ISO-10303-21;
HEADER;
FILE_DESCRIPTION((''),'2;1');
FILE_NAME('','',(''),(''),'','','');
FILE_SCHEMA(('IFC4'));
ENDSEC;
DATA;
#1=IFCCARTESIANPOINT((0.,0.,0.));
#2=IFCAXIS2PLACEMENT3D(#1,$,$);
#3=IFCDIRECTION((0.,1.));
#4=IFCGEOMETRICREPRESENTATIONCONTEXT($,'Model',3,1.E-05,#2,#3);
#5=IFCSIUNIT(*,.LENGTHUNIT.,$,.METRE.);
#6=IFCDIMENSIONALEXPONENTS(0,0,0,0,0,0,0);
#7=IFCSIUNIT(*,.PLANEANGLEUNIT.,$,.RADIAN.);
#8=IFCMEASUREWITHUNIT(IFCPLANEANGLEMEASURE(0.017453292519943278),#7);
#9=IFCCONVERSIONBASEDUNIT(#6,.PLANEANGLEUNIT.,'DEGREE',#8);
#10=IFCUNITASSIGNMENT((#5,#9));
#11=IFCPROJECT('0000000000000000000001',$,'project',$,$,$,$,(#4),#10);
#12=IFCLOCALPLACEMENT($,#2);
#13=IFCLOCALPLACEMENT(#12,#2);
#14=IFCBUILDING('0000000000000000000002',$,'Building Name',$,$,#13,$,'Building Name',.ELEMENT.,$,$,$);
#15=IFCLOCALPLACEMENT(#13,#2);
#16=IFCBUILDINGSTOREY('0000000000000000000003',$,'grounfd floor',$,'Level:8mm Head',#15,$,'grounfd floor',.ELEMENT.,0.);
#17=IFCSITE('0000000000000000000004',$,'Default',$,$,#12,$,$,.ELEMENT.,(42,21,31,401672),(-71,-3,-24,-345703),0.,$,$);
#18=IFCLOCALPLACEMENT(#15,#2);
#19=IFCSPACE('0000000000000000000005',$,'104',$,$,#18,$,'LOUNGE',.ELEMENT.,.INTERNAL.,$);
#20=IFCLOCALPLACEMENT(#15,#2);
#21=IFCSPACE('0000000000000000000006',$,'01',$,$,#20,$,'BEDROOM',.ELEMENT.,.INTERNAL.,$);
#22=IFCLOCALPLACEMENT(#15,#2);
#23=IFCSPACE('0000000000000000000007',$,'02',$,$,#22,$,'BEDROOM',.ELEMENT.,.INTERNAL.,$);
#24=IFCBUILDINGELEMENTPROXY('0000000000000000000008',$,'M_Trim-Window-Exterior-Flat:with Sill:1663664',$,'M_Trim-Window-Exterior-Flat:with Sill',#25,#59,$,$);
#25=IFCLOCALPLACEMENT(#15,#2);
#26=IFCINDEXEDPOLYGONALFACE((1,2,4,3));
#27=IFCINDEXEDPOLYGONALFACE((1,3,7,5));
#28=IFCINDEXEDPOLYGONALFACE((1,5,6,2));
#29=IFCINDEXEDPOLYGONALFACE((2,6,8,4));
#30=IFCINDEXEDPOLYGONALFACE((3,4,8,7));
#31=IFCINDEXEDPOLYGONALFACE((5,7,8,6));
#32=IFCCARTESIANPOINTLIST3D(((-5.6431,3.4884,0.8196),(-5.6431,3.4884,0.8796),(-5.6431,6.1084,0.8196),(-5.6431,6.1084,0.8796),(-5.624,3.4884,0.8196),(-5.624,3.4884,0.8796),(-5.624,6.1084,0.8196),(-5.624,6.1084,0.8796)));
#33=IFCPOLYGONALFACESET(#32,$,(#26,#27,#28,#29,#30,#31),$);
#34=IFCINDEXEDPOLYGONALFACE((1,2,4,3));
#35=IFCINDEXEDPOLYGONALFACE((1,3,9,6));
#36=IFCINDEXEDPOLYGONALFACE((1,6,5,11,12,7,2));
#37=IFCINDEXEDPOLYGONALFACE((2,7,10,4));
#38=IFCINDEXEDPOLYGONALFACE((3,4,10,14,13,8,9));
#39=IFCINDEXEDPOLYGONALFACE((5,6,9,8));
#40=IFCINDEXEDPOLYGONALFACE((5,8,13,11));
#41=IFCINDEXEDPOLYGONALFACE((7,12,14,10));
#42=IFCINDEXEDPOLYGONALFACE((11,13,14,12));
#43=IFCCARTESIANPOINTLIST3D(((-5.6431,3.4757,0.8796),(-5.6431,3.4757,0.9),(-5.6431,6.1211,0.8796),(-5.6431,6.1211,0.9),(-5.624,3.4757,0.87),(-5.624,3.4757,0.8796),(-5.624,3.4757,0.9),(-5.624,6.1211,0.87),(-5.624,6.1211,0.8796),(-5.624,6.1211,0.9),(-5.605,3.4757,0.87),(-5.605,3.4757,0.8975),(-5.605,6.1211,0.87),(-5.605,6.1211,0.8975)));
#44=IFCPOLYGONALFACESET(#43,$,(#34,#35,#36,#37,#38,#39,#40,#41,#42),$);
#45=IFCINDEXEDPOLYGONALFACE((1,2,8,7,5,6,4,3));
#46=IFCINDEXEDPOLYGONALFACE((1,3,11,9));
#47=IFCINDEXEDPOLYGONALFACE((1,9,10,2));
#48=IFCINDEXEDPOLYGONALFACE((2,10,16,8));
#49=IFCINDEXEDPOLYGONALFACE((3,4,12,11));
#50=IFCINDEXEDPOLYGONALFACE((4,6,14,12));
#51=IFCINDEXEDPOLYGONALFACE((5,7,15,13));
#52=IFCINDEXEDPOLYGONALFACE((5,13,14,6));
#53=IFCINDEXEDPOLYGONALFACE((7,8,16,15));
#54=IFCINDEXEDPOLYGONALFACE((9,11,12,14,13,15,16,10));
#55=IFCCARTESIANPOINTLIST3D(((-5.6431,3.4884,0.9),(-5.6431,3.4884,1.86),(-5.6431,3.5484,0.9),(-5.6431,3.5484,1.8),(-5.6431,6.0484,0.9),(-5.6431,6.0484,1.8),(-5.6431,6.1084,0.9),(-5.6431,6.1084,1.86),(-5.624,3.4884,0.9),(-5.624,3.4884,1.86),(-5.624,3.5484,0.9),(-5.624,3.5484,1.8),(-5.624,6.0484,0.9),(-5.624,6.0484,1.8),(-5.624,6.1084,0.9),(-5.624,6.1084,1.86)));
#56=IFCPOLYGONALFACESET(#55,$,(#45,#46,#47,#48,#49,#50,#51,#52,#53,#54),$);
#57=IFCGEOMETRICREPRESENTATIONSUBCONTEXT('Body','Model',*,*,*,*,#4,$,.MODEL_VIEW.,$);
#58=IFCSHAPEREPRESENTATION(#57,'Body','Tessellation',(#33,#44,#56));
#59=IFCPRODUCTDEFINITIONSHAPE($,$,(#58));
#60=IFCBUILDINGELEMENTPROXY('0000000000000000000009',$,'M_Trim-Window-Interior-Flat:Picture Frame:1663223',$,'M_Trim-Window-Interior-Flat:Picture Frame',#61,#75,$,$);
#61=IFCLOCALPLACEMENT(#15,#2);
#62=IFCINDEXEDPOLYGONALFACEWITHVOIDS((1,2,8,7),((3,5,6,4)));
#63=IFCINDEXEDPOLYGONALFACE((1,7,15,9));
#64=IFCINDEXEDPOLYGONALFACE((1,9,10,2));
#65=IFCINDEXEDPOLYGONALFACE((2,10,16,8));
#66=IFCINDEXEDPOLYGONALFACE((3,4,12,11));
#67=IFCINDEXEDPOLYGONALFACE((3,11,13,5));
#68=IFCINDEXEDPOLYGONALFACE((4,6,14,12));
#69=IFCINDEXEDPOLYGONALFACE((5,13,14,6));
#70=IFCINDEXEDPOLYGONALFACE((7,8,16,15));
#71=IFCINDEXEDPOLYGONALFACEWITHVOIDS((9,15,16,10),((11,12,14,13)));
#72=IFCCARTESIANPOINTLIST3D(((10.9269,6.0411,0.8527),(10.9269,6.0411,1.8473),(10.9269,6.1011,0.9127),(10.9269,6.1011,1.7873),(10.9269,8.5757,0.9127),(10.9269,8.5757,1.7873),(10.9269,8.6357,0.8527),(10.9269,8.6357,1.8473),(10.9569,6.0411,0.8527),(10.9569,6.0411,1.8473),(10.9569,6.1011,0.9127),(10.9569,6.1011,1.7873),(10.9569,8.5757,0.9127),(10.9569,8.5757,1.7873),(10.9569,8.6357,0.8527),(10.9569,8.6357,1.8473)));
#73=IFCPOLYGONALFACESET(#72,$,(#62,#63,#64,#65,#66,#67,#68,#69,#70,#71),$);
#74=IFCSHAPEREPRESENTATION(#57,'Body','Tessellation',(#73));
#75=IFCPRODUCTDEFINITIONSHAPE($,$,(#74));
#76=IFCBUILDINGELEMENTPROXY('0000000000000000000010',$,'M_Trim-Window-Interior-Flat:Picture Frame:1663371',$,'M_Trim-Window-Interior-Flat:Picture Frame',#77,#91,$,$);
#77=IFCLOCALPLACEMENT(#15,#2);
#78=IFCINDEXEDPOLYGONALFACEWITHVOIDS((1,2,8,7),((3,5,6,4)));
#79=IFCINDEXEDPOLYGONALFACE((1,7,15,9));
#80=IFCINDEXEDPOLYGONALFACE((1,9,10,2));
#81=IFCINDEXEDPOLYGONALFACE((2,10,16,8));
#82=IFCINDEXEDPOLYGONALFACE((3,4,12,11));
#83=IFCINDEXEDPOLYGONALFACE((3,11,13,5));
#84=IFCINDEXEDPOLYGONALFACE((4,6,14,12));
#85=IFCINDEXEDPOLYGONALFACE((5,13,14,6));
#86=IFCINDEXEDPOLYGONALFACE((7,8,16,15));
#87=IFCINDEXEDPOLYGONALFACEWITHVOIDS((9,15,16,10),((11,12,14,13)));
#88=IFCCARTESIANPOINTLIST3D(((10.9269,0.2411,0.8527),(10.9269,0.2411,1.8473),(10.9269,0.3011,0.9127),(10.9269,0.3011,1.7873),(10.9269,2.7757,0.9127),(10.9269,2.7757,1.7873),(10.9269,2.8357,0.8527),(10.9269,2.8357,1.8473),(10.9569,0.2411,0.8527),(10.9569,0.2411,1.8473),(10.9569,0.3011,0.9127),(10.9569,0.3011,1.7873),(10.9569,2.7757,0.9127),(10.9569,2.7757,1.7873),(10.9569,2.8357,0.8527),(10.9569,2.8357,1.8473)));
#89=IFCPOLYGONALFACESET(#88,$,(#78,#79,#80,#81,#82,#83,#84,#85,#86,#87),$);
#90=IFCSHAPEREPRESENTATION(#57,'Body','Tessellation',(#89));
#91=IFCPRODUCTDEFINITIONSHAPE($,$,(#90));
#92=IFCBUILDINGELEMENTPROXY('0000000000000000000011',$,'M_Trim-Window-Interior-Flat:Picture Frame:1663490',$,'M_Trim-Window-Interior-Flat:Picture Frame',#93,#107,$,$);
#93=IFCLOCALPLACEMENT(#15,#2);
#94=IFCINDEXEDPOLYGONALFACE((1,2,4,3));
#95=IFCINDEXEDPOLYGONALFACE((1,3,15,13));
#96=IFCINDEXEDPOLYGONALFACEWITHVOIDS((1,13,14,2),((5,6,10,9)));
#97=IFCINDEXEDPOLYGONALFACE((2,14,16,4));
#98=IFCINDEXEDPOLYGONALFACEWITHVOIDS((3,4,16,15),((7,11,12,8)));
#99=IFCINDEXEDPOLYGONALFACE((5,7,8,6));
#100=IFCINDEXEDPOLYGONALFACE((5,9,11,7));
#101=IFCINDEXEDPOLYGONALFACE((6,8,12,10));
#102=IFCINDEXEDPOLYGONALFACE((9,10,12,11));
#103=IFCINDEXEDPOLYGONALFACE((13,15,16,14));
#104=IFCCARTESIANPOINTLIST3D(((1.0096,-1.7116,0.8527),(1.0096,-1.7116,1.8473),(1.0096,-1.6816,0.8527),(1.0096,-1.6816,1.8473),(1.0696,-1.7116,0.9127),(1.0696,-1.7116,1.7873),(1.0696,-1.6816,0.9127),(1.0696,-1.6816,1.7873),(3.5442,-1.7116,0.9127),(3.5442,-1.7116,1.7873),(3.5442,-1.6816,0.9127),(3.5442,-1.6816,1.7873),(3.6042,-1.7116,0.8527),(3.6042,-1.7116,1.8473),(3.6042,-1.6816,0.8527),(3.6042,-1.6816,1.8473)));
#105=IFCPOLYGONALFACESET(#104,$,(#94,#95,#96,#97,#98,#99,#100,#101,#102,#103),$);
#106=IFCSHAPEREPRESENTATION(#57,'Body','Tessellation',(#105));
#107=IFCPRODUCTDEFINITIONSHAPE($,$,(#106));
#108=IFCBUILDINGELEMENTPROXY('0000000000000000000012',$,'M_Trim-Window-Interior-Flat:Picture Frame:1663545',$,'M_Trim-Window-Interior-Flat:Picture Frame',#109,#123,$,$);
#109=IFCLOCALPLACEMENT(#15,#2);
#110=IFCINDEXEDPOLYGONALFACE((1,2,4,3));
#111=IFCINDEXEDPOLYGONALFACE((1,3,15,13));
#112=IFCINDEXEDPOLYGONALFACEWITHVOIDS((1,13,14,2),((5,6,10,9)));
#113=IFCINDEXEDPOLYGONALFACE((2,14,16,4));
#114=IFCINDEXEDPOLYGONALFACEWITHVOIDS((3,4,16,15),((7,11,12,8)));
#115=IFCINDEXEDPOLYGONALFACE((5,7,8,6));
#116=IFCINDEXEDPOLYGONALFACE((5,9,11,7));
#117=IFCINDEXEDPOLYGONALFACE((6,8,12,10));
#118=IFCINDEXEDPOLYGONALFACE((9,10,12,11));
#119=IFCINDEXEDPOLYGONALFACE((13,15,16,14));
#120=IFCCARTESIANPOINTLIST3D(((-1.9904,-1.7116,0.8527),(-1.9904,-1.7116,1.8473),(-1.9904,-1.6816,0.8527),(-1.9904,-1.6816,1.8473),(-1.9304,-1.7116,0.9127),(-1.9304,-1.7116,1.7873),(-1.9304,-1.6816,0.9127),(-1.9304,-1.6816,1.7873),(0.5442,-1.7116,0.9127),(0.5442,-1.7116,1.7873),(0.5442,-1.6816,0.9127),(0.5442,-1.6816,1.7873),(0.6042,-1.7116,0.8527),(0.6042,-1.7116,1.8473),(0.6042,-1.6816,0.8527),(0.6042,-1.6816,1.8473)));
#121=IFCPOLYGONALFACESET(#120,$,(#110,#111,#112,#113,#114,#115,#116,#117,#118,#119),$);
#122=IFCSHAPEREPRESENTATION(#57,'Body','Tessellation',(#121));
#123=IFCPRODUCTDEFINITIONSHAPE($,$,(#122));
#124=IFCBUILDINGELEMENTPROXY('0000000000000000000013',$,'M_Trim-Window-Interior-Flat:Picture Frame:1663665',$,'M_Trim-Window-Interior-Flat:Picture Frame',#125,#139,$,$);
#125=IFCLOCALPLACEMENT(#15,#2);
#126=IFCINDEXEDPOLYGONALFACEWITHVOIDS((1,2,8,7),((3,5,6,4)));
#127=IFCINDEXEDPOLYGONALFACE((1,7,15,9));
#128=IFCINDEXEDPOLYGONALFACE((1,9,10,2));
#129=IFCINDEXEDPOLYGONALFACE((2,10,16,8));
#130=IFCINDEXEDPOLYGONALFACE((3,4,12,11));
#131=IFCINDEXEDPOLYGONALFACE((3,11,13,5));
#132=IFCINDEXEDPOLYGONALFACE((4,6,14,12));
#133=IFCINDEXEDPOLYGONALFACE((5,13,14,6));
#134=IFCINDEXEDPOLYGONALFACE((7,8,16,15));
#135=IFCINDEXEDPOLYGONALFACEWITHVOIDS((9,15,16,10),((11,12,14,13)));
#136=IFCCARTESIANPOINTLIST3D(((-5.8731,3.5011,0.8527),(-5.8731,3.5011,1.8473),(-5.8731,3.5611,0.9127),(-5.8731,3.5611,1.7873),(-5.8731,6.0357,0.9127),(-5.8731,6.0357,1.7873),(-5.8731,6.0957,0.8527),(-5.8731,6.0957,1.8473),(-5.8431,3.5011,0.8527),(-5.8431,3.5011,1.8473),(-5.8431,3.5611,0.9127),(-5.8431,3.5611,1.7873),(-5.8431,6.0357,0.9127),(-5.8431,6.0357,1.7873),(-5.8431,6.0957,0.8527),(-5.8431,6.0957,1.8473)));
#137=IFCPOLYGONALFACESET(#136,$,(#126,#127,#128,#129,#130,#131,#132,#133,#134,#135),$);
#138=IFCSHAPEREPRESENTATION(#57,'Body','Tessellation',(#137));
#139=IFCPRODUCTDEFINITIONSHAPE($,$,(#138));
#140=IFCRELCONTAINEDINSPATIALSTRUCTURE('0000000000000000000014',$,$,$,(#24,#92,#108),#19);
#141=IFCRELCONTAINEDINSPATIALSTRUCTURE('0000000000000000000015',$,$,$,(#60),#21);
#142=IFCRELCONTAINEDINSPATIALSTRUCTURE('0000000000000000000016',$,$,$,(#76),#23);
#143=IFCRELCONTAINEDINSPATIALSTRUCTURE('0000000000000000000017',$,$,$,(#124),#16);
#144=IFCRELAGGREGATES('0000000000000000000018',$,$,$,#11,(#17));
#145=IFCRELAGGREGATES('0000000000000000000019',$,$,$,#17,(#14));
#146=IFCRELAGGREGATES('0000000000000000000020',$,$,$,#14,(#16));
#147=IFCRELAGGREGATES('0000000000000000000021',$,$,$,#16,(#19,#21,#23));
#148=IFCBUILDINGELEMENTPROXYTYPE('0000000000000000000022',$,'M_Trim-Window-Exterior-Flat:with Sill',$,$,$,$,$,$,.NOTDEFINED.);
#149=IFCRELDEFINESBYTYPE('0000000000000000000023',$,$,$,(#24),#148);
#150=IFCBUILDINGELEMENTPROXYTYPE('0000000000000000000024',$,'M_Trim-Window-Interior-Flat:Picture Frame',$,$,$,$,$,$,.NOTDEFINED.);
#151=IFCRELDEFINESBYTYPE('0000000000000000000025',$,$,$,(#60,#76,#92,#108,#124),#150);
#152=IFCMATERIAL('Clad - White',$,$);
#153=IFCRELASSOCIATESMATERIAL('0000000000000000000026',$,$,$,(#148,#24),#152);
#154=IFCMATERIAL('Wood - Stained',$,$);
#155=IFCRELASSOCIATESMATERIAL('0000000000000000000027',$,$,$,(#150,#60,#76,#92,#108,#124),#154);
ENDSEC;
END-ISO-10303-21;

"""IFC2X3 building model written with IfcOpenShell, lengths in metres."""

from ifc_helpers import new_model, entity, si_unit, converted_unit, direction, frame, frame_2d, origin, place, context, subcontext, project, spatial, polyline, rectangle, outline, extrude, source, transform, mapped, material, type_object, type_shapes, element, save


model = new_model("IFC2X3")

# Units and contexts
model_context = context("Model", 3, precision=1e-05, world=origin(), true_north=direction((0.0, 1.0)))
body_context = subcontext(model_context, "Body", "Model", "MODEL_VIEW")
ifc_project = project(units=[si_unit("LENGTHUNIT", "METRE"), converted_unit("PLANEANGLEUNIT", "DEGREE", entity("IfcPlaneAngleMeasure", 0.017453292519943278), si_unit("PLANEANGLEUNIT", "RADIAN"), dimensions=[0, 0, 0, 0, 0, 0, 0])], contexts=[model_context])

# Site, building, storey
site_placement = place(None, origin())
site = spatial("IfcSite", under=ifc_project, at=site_placement, Name="Default", CompositionType="ELEMENT", RefLatitude=(42, 21, 31, 401672), RefLongitude=(-71, -3, -24, -345703), RefElevation=0.0)
building_placement = place(site_placement, origin())
building = spatial("IfcBuilding", under=site, at=building_placement, Name="Building Name", LongName="Building Name", CompositionType="ELEMENT")
storey_placement = place(building_placement, origin())
storey = spatial("IfcBuildingStorey", under=building, at=storey_placement, Name="grounfd floor", ObjectType="Level:8mm Head", LongName="grounfd floor", CompositionType="ELEMENT", Elevation=0.0)

# Shared definitions
ifc_material_1 = material(Name="Clad - White")
ifc_material_2 = material(Name="Wood - Stained")
building_element_proxy_type_1 = type_object("IfcBuildingElementProxyType", Name="M_Trim-Window-Exterior-Flat:with Sill", PredefinedType="NOTDEFINED", material=ifc_material_1)
shared_shape_1 = source(origin(), body_context, "Body", "SweptSolid", [
    extrude(rectangle(XDim=2.62, YDim=0.06, at=frame_2d((0.0, 0.0), x_axis=(1.0, 0.0))), frame((0.0, -0.9504, 0.0), z_axis=(0.0, 0.0, 1.0), x_axis=(-1.0, 0.0, 0.0)), (0.0, 0.0, 1.0), 0.019),
    extrude(outline(polyline([(-0.019, -0.0152), (0.0, -0.0152), (0.0, -0.0057), (0.019, -0.0057), (0.019, 0.0148), (0.0, 0.0148), (-0.019, 0.0123), (-0.019, -0.0152)])), frame((-1.3227, -0.9148, 0.019), z_axis=(1.0, 0.0, 0.0), x_axis=(0.0, 0.0, -1.0)), (0.0, 0.0, 1.0), 2.6454),
    extrude(outline(polyline([(-0.495, -1.31), (0.465, -1.31), (0.465, -1.25), (-0.435, -1.25), (-0.435, 1.25), (0.465, 1.25), (0.465, 1.31), (-0.495, 1.31), (-0.495, -1.31)])), frame((0.0, -0.435, 0.0), z_axis=(0.0, 0.0, 1.0), x_axis=(0.0, -1.0, 0.0)), (0.0, 0.0, 1.0), 0.019),
])
type_shapes(building_element_proxy_type_1, [shared_shape_1])

# Shared definitions
space_1_placement = place(storey_placement, origin())
space_1 = spatial("IfcSpace", under=storey, at=space_1_placement, Name="104", LongName="LOUNGE", CompositionType="ELEMENT", InteriorOrExteriorSpace="INTERNAL")

# Building element proxy
proxy_1_placement = place(space_1_placement, frame((-5.6431, 4.7984, 1.8), z_axis=(1.0, 0.0, 0.0), x_axis=(0.0, 1.0, 0.0)))
element("IfcBuildingElementProxy", 1, at=proxy_1_placement, inside=space_1, type_object=building_element_proxy_type_1, material=ifc_material_1, Name="M_Trim-Window-Exterior-Flat:with Sill:1663664", ObjectType="M_Trim-Window-Exterior-Flat:with Sill", context=body_context, shape_type="MappedRepresentation", body=[
    mapped(shared_shape_1, transform((0.0, 0.0, 0.0), scale=1.0)),
])

# Shared definitions
space_2_placement = place(storey_placement, origin())
space_2 = spatial("IfcSpace", under=storey, at=space_2_placement, Name="01", LongName="BEDROOM", CompositionType="ELEMENT", InteriorOrExteriorSpace="INTERNAL")

# Building element proxy
building_element_proxy_type_2 = type_object("IfcBuildingElementProxyType", Name="M_Trim-Window-Interior-Flat:Picture Frame", PredefinedType="NOTDEFINED", material=ifc_material_2)
shared_shape_2 = source(origin(), body_context, "Body", "SweptSolid", [
    extrude(outline(polyline([(-1.2973, -0.4973), (1.2973, -0.4973), (1.2973, 0.4973), (-1.2973, 0.4973), (-1.2973, -0.4973)]), holes=[polyline([(-1.2373, -0.4373), (-1.2373, 0.4373), (1.2373, 0.4373), (1.2373, -0.4373), (-1.2373, -0.4373)])]), frame((0.0, -0.45, 0.0), z_axis=(0.0, 0.0, 1.0), x_axis=(-1.0, 0.0, 0.0)), (0.0, 0.0, 1.0), 0.03),
])
type_shapes(building_element_proxy_type_2, [shared_shape_2])
proxy_2_placement = place(space_2_placement, frame((10.9569, 7.3384, 1.8), z_axis=(-1.0, 0.0, 0.0), x_axis=(0.0, -1.0, 0.0)))
element("IfcBuildingElementProxy", 2, at=proxy_2_placement, inside=space_2, type_object=building_element_proxy_type_2, material=ifc_material_2, Name="M_Trim-Window-Interior-Flat:Picture Frame:1663223", ObjectType="M_Trim-Window-Interior-Flat:Picture Frame", context=body_context, shape_type="MappedRepresentation", body=[
    mapped(shared_shape_2, transform((0.0, 0.0, 0.0), scale=1.0)),
])

# Shared definitions
space_3_placement = place(storey_placement, origin())
space_3 = spatial("IfcSpace", under=storey, at=space_3_placement, Name="02", LongName="BEDROOM", CompositionType="ELEMENT", InteriorOrExteriorSpace="INTERNAL")

# Building element proxies
proxy_3_placement = place(space_3_placement, frame((10.9569, 1.5384, 1.8), z_axis=(-1.0, 0.0, 0.0), x_axis=(0.0, -1.0, 0.0)))
element("IfcBuildingElementProxy", 3, at=proxy_3_placement, inside=space_3, type_object=building_element_proxy_type_2, material=ifc_material_2, Name="M_Trim-Window-Interior-Flat:Picture Frame:1663371", ObjectType="M_Trim-Window-Interior-Flat:Picture Frame", context=body_context, shape_type="MappedRepresentation", body=[
    mapped(shared_shape_2, transform((0.0, 0.0, 0.0), scale=1.0)),
])
for number, where, z_axis, x_axis, name in (
    (4, (2.3069, -1.7116, 1.8), (0.0, 1.0, 0.0), (-1.0, 0.0, 0.0), "M_Trim-Window-Interior-Flat:Picture Frame:1663490"),
    (5, (-0.6931, -1.7116, 1.8), (0.0, 1.0, 0.0), (-1.0, 0.0, 0.0), "M_Trim-Window-Interior-Flat:Picture Frame:1663545"),
):
    element("IfcBuildingElementProxy", number, at=place(space_1_placement, frame(where, z_axis=z_axis, x_axis=x_axis)), inside=space_1, type_object=building_element_proxy_type_2, material=ifc_material_2, Name=name, ObjectType="M_Trim-Window-Interior-Flat:Picture Frame", context=body_context, shape_type="MappedRepresentation", body=[
        mapped(shared_shape_2, transform((0.0, 0.0, 0.0), scale=1.0)),
    ])
proxy_4_placement = place(storey_placement, frame((-5.8431, 4.7984, 1.8), z_axis=(-1.0, 0.0, 0.0), x_axis=(0.0, -1.0, 0.0)))
element("IfcBuildingElementProxy", 6, at=proxy_4_placement, inside=storey, type_object=building_element_proxy_type_2, material=ifc_material_2, Name="M_Trim-Window-Interior-Flat:Picture Frame:1663665", ObjectType="M_Trim-Window-Interior-Flat:Picture Frame", context=body_context, shape_type="MappedRepresentation", body=[
    mapped(shared_shape_2, transform((0.0, 0.0, 0.0), scale=1.0)),
])

save(model, "model.ifc")
